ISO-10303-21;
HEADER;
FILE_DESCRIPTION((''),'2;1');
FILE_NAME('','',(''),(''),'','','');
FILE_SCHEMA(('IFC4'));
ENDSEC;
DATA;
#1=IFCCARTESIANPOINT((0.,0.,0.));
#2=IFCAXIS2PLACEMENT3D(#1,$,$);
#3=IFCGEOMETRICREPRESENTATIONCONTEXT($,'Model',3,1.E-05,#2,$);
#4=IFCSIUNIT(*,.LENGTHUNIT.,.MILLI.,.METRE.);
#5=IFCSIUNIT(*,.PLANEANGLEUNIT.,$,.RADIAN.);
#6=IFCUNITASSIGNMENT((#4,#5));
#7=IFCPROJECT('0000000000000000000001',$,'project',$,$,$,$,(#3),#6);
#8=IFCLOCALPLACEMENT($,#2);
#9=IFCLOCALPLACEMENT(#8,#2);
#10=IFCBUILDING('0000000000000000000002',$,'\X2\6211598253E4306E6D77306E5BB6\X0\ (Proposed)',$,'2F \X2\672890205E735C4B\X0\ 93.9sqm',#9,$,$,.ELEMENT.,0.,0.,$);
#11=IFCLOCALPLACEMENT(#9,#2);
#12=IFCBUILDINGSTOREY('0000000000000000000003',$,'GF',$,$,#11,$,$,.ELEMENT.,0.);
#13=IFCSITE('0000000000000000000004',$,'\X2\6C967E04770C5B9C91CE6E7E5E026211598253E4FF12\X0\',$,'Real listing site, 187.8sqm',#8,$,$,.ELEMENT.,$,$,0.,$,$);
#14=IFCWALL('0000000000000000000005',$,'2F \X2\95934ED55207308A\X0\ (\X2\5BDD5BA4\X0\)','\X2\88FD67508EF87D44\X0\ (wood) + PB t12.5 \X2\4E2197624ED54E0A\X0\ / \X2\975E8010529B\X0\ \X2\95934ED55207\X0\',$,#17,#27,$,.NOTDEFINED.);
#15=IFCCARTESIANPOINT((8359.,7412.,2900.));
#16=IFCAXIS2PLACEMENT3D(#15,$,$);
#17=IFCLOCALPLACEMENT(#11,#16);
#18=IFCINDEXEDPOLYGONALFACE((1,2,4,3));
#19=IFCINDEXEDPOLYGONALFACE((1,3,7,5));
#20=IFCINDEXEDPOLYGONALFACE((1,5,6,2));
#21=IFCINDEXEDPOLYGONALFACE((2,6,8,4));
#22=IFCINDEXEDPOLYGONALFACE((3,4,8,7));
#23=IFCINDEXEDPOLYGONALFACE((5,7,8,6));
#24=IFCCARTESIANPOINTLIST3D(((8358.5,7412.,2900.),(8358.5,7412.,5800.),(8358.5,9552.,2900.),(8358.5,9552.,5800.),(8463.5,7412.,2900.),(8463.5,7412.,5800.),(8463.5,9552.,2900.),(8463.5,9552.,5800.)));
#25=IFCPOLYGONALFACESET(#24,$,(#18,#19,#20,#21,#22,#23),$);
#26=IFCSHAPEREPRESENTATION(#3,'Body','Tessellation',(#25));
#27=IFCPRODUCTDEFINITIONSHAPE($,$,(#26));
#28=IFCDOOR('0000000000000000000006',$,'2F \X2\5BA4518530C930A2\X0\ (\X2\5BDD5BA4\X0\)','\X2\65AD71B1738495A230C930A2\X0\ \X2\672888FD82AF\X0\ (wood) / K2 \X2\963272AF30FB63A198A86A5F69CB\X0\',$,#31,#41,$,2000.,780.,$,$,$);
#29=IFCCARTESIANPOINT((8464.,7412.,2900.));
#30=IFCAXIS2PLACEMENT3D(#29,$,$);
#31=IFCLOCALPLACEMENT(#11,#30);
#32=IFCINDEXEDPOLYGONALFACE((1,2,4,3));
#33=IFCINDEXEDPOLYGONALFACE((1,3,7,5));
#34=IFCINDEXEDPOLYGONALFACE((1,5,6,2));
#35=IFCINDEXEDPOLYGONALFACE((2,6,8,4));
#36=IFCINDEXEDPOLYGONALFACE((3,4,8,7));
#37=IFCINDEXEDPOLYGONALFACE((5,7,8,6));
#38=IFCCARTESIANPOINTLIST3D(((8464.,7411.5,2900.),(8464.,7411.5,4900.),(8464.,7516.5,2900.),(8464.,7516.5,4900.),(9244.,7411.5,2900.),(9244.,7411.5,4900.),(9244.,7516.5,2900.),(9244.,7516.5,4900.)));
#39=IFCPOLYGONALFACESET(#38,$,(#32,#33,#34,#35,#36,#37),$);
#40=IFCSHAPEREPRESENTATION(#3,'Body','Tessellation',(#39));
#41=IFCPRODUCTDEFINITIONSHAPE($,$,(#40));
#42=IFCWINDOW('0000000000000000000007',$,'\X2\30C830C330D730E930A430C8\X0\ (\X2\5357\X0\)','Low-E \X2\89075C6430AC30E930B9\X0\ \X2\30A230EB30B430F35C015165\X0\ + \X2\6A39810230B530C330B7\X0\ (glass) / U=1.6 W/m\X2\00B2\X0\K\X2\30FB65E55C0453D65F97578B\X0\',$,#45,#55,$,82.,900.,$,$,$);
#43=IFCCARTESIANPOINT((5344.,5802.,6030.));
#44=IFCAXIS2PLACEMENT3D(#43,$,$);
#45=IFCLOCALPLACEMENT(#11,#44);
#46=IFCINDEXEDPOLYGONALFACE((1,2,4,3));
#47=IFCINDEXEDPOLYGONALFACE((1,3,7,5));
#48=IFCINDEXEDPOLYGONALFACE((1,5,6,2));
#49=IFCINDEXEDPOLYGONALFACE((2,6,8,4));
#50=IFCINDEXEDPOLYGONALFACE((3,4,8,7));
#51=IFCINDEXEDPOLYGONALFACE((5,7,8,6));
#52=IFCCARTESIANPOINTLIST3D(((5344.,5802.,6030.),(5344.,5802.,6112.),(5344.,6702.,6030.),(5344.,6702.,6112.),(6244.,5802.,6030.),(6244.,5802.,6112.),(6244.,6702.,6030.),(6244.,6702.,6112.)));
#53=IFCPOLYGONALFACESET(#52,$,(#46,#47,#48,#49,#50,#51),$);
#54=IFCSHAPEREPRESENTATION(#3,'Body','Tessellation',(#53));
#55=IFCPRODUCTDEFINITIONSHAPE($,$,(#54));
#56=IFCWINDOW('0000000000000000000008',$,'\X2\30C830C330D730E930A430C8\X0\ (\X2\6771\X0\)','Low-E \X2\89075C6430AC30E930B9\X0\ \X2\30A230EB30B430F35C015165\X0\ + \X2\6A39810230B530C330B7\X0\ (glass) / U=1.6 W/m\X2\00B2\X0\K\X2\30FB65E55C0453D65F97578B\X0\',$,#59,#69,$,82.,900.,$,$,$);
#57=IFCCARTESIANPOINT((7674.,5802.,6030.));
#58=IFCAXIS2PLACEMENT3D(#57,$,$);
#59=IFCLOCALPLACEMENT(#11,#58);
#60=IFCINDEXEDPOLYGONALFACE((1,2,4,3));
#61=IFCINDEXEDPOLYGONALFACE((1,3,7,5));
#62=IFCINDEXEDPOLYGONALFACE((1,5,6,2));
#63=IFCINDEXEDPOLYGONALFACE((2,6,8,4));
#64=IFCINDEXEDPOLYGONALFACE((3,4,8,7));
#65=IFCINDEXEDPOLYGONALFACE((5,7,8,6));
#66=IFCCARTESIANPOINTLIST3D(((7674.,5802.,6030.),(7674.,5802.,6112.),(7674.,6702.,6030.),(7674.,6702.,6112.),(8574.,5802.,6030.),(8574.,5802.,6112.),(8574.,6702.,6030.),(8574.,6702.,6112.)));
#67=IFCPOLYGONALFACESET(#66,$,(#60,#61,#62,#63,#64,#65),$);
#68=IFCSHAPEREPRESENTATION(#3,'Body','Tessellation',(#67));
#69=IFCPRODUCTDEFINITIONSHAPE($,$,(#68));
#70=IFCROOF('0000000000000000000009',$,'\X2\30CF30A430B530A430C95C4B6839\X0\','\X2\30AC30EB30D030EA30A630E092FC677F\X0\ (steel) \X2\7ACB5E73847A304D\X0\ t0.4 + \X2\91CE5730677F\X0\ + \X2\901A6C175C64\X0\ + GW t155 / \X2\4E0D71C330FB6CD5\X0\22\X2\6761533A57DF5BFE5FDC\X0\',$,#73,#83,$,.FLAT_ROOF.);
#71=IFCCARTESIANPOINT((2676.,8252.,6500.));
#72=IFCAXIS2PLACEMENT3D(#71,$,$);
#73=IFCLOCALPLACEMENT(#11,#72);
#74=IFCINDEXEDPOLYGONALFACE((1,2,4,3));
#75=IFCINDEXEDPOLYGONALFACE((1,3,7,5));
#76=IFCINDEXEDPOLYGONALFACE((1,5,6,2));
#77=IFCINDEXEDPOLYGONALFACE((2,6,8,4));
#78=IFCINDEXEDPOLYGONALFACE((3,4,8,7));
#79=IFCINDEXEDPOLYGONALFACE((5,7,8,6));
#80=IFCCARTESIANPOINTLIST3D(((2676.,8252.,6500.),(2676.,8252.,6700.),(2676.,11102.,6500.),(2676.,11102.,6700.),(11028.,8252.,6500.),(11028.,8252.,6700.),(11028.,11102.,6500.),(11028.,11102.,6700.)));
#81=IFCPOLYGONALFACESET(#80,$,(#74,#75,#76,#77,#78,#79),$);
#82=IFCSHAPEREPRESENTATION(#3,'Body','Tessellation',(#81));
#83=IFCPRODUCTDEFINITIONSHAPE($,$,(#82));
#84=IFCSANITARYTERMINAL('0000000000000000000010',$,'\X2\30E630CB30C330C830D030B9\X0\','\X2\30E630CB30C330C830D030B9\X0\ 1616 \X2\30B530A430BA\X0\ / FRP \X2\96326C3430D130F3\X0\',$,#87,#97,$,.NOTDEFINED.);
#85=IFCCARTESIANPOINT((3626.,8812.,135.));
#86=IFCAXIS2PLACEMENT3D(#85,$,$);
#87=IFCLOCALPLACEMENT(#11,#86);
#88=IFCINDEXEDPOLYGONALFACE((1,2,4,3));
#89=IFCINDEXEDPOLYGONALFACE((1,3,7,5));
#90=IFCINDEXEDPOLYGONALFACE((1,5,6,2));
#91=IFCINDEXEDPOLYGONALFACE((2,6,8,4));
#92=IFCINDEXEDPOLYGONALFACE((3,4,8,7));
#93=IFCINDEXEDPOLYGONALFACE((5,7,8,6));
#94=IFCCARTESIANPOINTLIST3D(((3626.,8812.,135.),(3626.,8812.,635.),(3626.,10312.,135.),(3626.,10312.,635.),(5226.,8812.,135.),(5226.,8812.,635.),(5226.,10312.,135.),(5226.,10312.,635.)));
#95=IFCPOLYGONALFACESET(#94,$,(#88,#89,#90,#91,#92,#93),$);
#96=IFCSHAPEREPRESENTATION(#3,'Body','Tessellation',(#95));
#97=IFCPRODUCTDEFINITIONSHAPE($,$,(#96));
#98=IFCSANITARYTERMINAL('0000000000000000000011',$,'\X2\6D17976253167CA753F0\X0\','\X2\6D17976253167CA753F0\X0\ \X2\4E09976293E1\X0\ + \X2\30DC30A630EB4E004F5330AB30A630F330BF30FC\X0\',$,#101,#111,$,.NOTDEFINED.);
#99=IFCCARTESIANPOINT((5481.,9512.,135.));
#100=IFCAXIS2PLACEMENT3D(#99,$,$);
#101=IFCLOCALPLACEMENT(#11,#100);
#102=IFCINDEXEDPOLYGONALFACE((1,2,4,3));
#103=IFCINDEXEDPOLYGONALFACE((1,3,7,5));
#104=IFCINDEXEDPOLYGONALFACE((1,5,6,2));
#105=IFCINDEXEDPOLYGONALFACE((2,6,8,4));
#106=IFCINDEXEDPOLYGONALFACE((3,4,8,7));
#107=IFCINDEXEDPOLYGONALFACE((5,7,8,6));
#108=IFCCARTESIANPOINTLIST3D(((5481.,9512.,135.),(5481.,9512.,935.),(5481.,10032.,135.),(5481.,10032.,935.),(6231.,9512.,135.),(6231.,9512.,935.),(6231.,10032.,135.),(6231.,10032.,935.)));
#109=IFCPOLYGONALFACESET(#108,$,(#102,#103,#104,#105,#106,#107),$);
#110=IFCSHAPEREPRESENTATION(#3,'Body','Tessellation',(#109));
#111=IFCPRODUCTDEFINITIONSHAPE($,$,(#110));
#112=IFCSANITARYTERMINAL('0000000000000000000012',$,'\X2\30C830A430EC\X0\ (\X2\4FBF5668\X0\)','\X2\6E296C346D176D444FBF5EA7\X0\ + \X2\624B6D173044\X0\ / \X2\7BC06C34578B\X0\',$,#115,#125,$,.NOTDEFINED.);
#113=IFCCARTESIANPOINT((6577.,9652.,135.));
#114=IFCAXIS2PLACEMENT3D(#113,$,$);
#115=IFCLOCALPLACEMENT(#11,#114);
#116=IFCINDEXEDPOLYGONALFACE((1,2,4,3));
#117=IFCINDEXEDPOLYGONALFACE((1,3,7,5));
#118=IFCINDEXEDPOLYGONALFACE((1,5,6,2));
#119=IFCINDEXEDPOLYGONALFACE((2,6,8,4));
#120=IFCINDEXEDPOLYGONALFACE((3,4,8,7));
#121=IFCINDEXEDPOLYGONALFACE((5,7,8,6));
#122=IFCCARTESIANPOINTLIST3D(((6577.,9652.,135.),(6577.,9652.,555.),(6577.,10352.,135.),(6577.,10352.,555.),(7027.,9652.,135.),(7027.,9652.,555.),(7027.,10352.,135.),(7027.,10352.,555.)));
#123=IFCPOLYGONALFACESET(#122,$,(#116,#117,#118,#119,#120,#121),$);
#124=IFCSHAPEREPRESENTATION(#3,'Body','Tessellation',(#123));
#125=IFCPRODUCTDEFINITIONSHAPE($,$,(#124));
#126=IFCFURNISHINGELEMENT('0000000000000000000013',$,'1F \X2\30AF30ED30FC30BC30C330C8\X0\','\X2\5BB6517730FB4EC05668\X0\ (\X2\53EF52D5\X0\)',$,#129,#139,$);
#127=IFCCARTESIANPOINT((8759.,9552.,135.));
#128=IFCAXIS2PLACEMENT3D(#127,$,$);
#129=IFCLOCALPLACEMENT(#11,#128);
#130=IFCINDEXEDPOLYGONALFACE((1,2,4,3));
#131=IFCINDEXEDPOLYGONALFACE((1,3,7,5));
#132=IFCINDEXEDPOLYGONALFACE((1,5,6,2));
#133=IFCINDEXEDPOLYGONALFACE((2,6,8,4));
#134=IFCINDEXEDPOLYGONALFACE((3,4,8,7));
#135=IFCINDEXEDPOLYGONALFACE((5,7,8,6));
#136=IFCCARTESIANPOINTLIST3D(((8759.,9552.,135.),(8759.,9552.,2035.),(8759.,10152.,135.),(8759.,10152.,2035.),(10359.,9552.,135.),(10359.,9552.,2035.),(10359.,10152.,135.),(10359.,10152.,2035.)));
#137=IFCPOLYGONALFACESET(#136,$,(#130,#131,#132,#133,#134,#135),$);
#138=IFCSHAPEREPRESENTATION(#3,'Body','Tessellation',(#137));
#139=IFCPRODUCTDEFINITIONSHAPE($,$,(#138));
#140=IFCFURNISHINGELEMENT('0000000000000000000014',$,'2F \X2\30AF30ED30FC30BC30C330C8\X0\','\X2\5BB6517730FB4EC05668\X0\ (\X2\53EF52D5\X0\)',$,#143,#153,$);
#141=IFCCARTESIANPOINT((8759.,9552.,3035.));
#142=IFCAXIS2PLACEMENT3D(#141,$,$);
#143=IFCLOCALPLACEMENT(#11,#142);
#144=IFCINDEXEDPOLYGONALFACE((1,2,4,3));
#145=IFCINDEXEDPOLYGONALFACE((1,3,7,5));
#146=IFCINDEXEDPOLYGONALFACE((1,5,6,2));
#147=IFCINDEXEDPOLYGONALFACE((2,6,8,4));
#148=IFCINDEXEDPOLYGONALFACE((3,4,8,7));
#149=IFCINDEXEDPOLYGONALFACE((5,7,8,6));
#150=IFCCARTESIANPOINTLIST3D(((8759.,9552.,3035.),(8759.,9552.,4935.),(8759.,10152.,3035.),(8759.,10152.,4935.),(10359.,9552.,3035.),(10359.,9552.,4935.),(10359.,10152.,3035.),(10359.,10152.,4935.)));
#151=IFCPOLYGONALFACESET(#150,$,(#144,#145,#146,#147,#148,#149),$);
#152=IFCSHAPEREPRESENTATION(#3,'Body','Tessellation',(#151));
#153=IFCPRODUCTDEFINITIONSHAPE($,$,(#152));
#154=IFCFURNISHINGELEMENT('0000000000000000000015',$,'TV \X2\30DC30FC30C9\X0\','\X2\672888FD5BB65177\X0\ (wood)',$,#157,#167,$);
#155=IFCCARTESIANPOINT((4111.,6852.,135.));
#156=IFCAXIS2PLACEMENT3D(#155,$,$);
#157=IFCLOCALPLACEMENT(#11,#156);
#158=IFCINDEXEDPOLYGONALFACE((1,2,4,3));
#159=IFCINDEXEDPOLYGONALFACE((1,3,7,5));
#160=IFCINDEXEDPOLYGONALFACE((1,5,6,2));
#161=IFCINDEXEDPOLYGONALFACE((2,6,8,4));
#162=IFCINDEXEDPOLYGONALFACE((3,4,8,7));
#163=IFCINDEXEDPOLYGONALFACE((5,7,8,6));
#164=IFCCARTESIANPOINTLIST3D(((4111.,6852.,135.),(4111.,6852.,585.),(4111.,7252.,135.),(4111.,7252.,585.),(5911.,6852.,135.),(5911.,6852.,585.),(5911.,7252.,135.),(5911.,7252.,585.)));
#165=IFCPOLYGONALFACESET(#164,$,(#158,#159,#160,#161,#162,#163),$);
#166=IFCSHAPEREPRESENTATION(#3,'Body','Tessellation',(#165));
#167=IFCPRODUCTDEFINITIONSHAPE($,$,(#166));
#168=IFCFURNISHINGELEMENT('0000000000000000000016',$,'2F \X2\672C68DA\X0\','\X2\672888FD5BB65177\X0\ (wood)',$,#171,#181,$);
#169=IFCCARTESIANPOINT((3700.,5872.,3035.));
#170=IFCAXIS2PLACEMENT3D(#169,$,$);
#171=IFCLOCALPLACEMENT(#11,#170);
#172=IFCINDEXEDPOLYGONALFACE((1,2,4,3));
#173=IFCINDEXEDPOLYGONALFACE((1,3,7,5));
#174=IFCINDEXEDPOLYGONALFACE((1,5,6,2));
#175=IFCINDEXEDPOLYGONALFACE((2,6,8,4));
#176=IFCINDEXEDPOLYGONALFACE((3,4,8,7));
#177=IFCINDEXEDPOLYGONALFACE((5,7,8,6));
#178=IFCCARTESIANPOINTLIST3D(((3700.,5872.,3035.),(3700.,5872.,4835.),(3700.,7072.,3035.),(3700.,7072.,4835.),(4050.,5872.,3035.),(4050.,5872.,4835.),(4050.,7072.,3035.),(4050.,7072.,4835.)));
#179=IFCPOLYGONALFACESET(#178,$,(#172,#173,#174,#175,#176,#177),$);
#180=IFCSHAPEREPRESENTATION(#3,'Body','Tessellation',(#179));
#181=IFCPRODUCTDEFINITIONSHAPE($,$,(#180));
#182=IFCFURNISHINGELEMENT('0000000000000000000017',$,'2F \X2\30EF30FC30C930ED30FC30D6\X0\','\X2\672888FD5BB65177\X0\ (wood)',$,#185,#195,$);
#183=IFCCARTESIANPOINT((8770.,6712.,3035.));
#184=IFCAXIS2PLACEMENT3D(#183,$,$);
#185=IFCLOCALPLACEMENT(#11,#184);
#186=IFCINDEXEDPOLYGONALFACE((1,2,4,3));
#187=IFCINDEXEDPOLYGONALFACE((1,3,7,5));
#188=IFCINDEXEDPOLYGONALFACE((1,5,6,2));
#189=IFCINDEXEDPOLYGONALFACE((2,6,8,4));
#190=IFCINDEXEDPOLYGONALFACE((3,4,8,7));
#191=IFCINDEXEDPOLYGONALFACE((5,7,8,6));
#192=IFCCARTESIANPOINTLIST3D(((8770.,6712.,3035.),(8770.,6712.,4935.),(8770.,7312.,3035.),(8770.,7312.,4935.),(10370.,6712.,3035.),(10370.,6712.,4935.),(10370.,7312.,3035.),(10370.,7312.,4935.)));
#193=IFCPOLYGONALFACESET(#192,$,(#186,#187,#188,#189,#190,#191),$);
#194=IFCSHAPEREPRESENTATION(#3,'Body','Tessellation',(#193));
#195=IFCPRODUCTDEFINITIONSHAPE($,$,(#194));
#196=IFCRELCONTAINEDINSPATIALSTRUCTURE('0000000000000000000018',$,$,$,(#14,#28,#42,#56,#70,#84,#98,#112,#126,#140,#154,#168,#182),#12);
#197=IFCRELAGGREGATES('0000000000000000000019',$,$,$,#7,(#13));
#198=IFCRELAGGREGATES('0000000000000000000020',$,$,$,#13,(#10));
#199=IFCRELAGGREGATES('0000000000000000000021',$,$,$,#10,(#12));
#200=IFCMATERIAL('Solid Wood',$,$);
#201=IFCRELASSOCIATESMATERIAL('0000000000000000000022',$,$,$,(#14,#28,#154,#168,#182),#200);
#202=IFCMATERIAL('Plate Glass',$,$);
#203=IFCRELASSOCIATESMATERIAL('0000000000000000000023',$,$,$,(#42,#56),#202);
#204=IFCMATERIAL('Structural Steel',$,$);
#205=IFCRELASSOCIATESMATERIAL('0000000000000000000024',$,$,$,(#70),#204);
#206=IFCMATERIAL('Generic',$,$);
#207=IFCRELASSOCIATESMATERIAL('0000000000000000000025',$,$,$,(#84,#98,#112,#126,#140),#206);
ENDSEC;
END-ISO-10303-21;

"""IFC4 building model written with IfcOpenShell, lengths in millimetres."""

from ifc_helpers import new_model, si_unit, frame, frame_2d, origin, place, context, project, spatial, rectangle, extrude, material, element, save


model = new_model("IFC4")

# Units and contexts
model_context = context("Model", 3, precision=1e-05, world=origin())
ifc_project = project(units=[si_unit("LENGTHUNIT", "METRE", prefix="MILLI"), si_unit("PLANEANGLEUNIT", "RADIAN")], contexts=[model_context])

# Site, building, storey
site_placement = place(None, origin())
site = spatial("IfcSite", under=ifc_project, at=site_placement, Name="沖縄県宜野湾市我如古２", ObjectType="Real listing site, 187.8sqm", CompositionType="ELEMENT", RefElevation=0.0)
building_placement = place(site_placement, origin())
building = spatial("IfcBuilding", under=site, at=building_placement, Name="我如古の海の家 (Proposed)", ObjectType="2F 木造平屋 93.9sqm", CompositionType="ELEMENT", ElevationOfRefHeight=0.0, ElevationOfTerrain=0.0)
storey_placement = place(building_placement, origin())
storey = spatial("IfcBuildingStorey", under=building, at=storey_placement, Name="GF", CompositionType="ELEMENT", Elevation=0.0)

# Shared definitions
ifc_material_1 = material(Name="Solid Wood")
ifc_material_2 = material(Name="Plate Glass")

# Wall
wall_1_placement = place(storey_placement, frame((8359.0, 7412.0, 2900.0)))
element("IfcWall", 1, at=wall_1_placement, inside=storey, material=ifc_material_1, Name="2F 間仕切り (寝室)", Description="製材軸組 (wood) + PB t12.5 両面仕上 / 非耐力 間仕切", PredefinedType="NOTDEFINED", context=model_context, shape_type="SweptSolid", body=[
    extrude(rectangle(XDim=105.0, YDim=2140.0, at=frame_2d((52.0, 1070.0))), frame((8359.0, 7412.0, 2900.0)), (0.0, 0.0, 1.0), 2900.0),
])

# Door
door_1_placement = place(storey_placement, frame((8464.0, 7412.0, 2900.0)))
element("IfcDoor", 2, at=door_1_placement, inside=storey, material=ifc_material_1, Name="2F 室内ドア (寝室)", Description="断熱玄関ドア 木製芯 (wood) / K2 防犯・採風機構", OverallHeight=2000.0, OverallWidth=780.0, context=model_context, shape_type="SweptSolid", body=[
    extrude(rectangle(XDim=780.0, YDim=105.0, at=frame_2d((390.0, 52.0))), frame((8464.0, 7412.0, 2900.0)), (0.0, 0.0, 1.0), 2000.0),
])

# Windows
window_1_placement = place(storey_placement, frame((5344.0, 5802.0, 6030.0)))
element("IfcWindow", 3, at=window_1_placement, inside=storey, material=ifc_material_2, Name="トップライト (南)", Description="Low-E 複層ガラス アルゴン封入 + 樹脂サッシ (glass) / U=1.6 W/m²K・日射取得型", OverallHeight=82.0, OverallWidth=900.0, context=model_context, shape_type="SweptSolid", body=[
    extrude(rectangle(XDim=900.0, YDim=900.0, at=frame_2d((450.0, 450.0))), frame((5344.0, 5802.0, 6030.0)), (0.0, 0.0, 1.0), 82.0),
])
window_2_placement = place(storey_placement, frame((7674.0, 5802.0, 6030.0)))
element("IfcWindow", 4, at=window_2_placement, inside=storey, material=ifc_material_2, Name="トップライト (東)", Description="Low-E 複層ガラス アルゴン封入 + 樹脂サッシ (glass) / U=1.6 W/m²K・日射取得型", OverallHeight=82.0, OverallWidth=900.0, context=model_context, shape_type="SweptSolid", body=[
    extrude(rectangle(XDim=900.0, YDim=900.0, at=frame_2d((450.0, 450.0))), frame((7674.0, 5802.0, 6030.0)), (0.0, 0.0, 1.0), 82.0),
])

# Roof
ifc_material_3 = material(Name="Structural Steel")
roof_placement = place(storey_placement, frame((2676.0, 8252.0, 6500.0)))
element("IfcRoof", 5, at=roof_placement, inside=storey, material=ifc_material_3, Name="ハイサイド屋根", Description="ガルバリウム鋼板 (steel) 立平葺き t0.4 + 野地板 + 通気層 + GW t155 / 不燃・法22条区域対応", PredefinedType="FLAT_ROOF", context=model_context, shape_type="SweptSolid", body=[
    extrude(rectangle(XDim=8352.0, YDim=2850.0, at=frame_2d((4176.0, 1425.0))), frame((2676.0, 8252.0, 6500.0)), (0.0, 0.0, 1.0), 200.0),
])

# Sanitary terminals
ifc_material_4 = material(Name="Generic")
sanitary_terminal_1_placement = place(storey_placement, frame((3626.0, 8812.0, 135.0)))
element("IfcSanitaryTerminal", 6, at=sanitary_terminal_1_placement, inside=storey, material=ifc_material_4, Name="ユニットバス", Description="ユニットバス 1616 サイズ / FRP 防水パン", PredefinedType="NOTDEFINED", context=model_context, shape_type="SweptSolid", body=[
    extrude(rectangle(XDim=1600.0, YDim=1500.0, at=frame_2d((800.0, 750.0))), frame((3626.0, 8812.0, 135.0)), (0.0, 0.0, 1.0), 500.0),
])
sanitary_terminal_2_placement = place(storey_placement, frame((5481.0, 9512.0, 135.0)))
element("IfcSanitaryTerminal", 7, at=sanitary_terminal_2_placement, inside=storey, material=ifc_material_4, Name="洗面化粧台", Description="洗面化粧台 三面鏡 + ボウル一体カウンター", PredefinedType="NOTDEFINED", context=model_context, shape_type="SweptSolid", body=[
    extrude(rectangle(XDim=750.0, YDim=520.0, at=frame_2d((375.0, 260.0))), frame((5481.0, 9512.0, 135.0)), (0.0, 0.0, 1.0), 800.0),
])
sanitary_terminal_3_placement = place(storey_placement, frame((6577.0, 9652.0, 135.0)))
element("IfcSanitaryTerminal", 8, at=sanitary_terminal_3_placement, inside=storey, material=ifc_material_4, Name="トイレ (便器)", Description="温水洗浄便座 + 手洗い / 節水型", PredefinedType="NOTDEFINED", context=model_context, shape_type="SweptSolid", body=[
    extrude(rectangle(XDim=450.0, YDim=700.0, at=frame_2d((225.0, 350.0))), frame((6577.0, 9652.0, 135.0)), (0.0, 0.0, 1.0), 420.0),
])

# Furnishing elements
furnishing_1_placement = place(storey_placement, frame((8759.0, 9552.0, 135.0)))
element("IfcFurnishingElement", 9, at=furnishing_1_placement, inside=storey, material=ifc_material_4, Name="1F クローゼット", Description="家具・什器 (可動)", context=model_context, shape_type="SweptSolid", body=[
    extrude(rectangle(XDim=1600.0, YDim=600.0, at=frame_2d((800.0, 300.0))), frame((8759.0, 9552.0, 135.0)), (0.0, 0.0, 1.0), 1900.0),
])
furnishing_2_placement = place(storey_placement, frame((8759.0, 9552.0, 3035.0)))
element("IfcFurnishingElement", 10, at=furnishing_2_placement, inside=storey, material=ifc_material_4, Name="2F クローゼット", Description="家具・什器 (可動)", context=model_context, shape_type="SweptSolid", body=[
    extrude(rectangle(XDim=1600.0, YDim=600.0, at=frame_2d((800.0, 300.0))), frame((8759.0, 9552.0, 3035.0)), (0.0, 0.0, 1.0), 1900.0),
])
furnishing_3_placement = place(storey_placement, frame((4111.0, 6852.0, 135.0)))
element("IfcFurnishingElement", 11, at=furnishing_3_placement, inside=storey, material=ifc_material_1, Name="TV ボード", Description="木製家具 (wood)", context=model_context, shape_type="SweptSolid", body=[
    extrude(rectangle(XDim=1800.0, YDim=400.0, at=frame_2d((900.0, 200.0))), frame((4111.0, 6852.0, 135.0)), (0.0, 0.0, 1.0), 450.0),
])
furnishing_4_placement = place(storey_placement, frame((3700.0, 5872.0, 3035.0)))
element("IfcFurnishingElement", 12, at=furnishing_4_placement, inside=storey, material=ifc_material_1, Name="2F 本棚", Description="木製家具 (wood)", context=model_context, shape_type="SweptSolid", body=[
    extrude(rectangle(XDim=350.0, YDim=1200.0, at=frame_2d((175.0, 600.0))), frame((3700.0, 5872.0, 3035.0)), (0.0, 0.0, 1.0), 1800.0),
])
furnishing_5_placement = place(storey_placement, frame((8770.0, 6712.0, 3035.0)))
element("IfcFurnishingElement", 13, at=furnishing_5_placement, inside=storey, material=ifc_material_1, Name="2F ワードローブ", Description="木製家具 (wood)", context=model_context, shape_type="SweptSolid", body=[
    extrude(rectangle(XDim=1600.0, YDim=600.0, at=frame_2d((800.0, 300.0))), frame((8770.0, 6712.0, 3035.0)), (0.0, 0.0, 1.0), 1900.0),
])

save(model, "model.ifc")
